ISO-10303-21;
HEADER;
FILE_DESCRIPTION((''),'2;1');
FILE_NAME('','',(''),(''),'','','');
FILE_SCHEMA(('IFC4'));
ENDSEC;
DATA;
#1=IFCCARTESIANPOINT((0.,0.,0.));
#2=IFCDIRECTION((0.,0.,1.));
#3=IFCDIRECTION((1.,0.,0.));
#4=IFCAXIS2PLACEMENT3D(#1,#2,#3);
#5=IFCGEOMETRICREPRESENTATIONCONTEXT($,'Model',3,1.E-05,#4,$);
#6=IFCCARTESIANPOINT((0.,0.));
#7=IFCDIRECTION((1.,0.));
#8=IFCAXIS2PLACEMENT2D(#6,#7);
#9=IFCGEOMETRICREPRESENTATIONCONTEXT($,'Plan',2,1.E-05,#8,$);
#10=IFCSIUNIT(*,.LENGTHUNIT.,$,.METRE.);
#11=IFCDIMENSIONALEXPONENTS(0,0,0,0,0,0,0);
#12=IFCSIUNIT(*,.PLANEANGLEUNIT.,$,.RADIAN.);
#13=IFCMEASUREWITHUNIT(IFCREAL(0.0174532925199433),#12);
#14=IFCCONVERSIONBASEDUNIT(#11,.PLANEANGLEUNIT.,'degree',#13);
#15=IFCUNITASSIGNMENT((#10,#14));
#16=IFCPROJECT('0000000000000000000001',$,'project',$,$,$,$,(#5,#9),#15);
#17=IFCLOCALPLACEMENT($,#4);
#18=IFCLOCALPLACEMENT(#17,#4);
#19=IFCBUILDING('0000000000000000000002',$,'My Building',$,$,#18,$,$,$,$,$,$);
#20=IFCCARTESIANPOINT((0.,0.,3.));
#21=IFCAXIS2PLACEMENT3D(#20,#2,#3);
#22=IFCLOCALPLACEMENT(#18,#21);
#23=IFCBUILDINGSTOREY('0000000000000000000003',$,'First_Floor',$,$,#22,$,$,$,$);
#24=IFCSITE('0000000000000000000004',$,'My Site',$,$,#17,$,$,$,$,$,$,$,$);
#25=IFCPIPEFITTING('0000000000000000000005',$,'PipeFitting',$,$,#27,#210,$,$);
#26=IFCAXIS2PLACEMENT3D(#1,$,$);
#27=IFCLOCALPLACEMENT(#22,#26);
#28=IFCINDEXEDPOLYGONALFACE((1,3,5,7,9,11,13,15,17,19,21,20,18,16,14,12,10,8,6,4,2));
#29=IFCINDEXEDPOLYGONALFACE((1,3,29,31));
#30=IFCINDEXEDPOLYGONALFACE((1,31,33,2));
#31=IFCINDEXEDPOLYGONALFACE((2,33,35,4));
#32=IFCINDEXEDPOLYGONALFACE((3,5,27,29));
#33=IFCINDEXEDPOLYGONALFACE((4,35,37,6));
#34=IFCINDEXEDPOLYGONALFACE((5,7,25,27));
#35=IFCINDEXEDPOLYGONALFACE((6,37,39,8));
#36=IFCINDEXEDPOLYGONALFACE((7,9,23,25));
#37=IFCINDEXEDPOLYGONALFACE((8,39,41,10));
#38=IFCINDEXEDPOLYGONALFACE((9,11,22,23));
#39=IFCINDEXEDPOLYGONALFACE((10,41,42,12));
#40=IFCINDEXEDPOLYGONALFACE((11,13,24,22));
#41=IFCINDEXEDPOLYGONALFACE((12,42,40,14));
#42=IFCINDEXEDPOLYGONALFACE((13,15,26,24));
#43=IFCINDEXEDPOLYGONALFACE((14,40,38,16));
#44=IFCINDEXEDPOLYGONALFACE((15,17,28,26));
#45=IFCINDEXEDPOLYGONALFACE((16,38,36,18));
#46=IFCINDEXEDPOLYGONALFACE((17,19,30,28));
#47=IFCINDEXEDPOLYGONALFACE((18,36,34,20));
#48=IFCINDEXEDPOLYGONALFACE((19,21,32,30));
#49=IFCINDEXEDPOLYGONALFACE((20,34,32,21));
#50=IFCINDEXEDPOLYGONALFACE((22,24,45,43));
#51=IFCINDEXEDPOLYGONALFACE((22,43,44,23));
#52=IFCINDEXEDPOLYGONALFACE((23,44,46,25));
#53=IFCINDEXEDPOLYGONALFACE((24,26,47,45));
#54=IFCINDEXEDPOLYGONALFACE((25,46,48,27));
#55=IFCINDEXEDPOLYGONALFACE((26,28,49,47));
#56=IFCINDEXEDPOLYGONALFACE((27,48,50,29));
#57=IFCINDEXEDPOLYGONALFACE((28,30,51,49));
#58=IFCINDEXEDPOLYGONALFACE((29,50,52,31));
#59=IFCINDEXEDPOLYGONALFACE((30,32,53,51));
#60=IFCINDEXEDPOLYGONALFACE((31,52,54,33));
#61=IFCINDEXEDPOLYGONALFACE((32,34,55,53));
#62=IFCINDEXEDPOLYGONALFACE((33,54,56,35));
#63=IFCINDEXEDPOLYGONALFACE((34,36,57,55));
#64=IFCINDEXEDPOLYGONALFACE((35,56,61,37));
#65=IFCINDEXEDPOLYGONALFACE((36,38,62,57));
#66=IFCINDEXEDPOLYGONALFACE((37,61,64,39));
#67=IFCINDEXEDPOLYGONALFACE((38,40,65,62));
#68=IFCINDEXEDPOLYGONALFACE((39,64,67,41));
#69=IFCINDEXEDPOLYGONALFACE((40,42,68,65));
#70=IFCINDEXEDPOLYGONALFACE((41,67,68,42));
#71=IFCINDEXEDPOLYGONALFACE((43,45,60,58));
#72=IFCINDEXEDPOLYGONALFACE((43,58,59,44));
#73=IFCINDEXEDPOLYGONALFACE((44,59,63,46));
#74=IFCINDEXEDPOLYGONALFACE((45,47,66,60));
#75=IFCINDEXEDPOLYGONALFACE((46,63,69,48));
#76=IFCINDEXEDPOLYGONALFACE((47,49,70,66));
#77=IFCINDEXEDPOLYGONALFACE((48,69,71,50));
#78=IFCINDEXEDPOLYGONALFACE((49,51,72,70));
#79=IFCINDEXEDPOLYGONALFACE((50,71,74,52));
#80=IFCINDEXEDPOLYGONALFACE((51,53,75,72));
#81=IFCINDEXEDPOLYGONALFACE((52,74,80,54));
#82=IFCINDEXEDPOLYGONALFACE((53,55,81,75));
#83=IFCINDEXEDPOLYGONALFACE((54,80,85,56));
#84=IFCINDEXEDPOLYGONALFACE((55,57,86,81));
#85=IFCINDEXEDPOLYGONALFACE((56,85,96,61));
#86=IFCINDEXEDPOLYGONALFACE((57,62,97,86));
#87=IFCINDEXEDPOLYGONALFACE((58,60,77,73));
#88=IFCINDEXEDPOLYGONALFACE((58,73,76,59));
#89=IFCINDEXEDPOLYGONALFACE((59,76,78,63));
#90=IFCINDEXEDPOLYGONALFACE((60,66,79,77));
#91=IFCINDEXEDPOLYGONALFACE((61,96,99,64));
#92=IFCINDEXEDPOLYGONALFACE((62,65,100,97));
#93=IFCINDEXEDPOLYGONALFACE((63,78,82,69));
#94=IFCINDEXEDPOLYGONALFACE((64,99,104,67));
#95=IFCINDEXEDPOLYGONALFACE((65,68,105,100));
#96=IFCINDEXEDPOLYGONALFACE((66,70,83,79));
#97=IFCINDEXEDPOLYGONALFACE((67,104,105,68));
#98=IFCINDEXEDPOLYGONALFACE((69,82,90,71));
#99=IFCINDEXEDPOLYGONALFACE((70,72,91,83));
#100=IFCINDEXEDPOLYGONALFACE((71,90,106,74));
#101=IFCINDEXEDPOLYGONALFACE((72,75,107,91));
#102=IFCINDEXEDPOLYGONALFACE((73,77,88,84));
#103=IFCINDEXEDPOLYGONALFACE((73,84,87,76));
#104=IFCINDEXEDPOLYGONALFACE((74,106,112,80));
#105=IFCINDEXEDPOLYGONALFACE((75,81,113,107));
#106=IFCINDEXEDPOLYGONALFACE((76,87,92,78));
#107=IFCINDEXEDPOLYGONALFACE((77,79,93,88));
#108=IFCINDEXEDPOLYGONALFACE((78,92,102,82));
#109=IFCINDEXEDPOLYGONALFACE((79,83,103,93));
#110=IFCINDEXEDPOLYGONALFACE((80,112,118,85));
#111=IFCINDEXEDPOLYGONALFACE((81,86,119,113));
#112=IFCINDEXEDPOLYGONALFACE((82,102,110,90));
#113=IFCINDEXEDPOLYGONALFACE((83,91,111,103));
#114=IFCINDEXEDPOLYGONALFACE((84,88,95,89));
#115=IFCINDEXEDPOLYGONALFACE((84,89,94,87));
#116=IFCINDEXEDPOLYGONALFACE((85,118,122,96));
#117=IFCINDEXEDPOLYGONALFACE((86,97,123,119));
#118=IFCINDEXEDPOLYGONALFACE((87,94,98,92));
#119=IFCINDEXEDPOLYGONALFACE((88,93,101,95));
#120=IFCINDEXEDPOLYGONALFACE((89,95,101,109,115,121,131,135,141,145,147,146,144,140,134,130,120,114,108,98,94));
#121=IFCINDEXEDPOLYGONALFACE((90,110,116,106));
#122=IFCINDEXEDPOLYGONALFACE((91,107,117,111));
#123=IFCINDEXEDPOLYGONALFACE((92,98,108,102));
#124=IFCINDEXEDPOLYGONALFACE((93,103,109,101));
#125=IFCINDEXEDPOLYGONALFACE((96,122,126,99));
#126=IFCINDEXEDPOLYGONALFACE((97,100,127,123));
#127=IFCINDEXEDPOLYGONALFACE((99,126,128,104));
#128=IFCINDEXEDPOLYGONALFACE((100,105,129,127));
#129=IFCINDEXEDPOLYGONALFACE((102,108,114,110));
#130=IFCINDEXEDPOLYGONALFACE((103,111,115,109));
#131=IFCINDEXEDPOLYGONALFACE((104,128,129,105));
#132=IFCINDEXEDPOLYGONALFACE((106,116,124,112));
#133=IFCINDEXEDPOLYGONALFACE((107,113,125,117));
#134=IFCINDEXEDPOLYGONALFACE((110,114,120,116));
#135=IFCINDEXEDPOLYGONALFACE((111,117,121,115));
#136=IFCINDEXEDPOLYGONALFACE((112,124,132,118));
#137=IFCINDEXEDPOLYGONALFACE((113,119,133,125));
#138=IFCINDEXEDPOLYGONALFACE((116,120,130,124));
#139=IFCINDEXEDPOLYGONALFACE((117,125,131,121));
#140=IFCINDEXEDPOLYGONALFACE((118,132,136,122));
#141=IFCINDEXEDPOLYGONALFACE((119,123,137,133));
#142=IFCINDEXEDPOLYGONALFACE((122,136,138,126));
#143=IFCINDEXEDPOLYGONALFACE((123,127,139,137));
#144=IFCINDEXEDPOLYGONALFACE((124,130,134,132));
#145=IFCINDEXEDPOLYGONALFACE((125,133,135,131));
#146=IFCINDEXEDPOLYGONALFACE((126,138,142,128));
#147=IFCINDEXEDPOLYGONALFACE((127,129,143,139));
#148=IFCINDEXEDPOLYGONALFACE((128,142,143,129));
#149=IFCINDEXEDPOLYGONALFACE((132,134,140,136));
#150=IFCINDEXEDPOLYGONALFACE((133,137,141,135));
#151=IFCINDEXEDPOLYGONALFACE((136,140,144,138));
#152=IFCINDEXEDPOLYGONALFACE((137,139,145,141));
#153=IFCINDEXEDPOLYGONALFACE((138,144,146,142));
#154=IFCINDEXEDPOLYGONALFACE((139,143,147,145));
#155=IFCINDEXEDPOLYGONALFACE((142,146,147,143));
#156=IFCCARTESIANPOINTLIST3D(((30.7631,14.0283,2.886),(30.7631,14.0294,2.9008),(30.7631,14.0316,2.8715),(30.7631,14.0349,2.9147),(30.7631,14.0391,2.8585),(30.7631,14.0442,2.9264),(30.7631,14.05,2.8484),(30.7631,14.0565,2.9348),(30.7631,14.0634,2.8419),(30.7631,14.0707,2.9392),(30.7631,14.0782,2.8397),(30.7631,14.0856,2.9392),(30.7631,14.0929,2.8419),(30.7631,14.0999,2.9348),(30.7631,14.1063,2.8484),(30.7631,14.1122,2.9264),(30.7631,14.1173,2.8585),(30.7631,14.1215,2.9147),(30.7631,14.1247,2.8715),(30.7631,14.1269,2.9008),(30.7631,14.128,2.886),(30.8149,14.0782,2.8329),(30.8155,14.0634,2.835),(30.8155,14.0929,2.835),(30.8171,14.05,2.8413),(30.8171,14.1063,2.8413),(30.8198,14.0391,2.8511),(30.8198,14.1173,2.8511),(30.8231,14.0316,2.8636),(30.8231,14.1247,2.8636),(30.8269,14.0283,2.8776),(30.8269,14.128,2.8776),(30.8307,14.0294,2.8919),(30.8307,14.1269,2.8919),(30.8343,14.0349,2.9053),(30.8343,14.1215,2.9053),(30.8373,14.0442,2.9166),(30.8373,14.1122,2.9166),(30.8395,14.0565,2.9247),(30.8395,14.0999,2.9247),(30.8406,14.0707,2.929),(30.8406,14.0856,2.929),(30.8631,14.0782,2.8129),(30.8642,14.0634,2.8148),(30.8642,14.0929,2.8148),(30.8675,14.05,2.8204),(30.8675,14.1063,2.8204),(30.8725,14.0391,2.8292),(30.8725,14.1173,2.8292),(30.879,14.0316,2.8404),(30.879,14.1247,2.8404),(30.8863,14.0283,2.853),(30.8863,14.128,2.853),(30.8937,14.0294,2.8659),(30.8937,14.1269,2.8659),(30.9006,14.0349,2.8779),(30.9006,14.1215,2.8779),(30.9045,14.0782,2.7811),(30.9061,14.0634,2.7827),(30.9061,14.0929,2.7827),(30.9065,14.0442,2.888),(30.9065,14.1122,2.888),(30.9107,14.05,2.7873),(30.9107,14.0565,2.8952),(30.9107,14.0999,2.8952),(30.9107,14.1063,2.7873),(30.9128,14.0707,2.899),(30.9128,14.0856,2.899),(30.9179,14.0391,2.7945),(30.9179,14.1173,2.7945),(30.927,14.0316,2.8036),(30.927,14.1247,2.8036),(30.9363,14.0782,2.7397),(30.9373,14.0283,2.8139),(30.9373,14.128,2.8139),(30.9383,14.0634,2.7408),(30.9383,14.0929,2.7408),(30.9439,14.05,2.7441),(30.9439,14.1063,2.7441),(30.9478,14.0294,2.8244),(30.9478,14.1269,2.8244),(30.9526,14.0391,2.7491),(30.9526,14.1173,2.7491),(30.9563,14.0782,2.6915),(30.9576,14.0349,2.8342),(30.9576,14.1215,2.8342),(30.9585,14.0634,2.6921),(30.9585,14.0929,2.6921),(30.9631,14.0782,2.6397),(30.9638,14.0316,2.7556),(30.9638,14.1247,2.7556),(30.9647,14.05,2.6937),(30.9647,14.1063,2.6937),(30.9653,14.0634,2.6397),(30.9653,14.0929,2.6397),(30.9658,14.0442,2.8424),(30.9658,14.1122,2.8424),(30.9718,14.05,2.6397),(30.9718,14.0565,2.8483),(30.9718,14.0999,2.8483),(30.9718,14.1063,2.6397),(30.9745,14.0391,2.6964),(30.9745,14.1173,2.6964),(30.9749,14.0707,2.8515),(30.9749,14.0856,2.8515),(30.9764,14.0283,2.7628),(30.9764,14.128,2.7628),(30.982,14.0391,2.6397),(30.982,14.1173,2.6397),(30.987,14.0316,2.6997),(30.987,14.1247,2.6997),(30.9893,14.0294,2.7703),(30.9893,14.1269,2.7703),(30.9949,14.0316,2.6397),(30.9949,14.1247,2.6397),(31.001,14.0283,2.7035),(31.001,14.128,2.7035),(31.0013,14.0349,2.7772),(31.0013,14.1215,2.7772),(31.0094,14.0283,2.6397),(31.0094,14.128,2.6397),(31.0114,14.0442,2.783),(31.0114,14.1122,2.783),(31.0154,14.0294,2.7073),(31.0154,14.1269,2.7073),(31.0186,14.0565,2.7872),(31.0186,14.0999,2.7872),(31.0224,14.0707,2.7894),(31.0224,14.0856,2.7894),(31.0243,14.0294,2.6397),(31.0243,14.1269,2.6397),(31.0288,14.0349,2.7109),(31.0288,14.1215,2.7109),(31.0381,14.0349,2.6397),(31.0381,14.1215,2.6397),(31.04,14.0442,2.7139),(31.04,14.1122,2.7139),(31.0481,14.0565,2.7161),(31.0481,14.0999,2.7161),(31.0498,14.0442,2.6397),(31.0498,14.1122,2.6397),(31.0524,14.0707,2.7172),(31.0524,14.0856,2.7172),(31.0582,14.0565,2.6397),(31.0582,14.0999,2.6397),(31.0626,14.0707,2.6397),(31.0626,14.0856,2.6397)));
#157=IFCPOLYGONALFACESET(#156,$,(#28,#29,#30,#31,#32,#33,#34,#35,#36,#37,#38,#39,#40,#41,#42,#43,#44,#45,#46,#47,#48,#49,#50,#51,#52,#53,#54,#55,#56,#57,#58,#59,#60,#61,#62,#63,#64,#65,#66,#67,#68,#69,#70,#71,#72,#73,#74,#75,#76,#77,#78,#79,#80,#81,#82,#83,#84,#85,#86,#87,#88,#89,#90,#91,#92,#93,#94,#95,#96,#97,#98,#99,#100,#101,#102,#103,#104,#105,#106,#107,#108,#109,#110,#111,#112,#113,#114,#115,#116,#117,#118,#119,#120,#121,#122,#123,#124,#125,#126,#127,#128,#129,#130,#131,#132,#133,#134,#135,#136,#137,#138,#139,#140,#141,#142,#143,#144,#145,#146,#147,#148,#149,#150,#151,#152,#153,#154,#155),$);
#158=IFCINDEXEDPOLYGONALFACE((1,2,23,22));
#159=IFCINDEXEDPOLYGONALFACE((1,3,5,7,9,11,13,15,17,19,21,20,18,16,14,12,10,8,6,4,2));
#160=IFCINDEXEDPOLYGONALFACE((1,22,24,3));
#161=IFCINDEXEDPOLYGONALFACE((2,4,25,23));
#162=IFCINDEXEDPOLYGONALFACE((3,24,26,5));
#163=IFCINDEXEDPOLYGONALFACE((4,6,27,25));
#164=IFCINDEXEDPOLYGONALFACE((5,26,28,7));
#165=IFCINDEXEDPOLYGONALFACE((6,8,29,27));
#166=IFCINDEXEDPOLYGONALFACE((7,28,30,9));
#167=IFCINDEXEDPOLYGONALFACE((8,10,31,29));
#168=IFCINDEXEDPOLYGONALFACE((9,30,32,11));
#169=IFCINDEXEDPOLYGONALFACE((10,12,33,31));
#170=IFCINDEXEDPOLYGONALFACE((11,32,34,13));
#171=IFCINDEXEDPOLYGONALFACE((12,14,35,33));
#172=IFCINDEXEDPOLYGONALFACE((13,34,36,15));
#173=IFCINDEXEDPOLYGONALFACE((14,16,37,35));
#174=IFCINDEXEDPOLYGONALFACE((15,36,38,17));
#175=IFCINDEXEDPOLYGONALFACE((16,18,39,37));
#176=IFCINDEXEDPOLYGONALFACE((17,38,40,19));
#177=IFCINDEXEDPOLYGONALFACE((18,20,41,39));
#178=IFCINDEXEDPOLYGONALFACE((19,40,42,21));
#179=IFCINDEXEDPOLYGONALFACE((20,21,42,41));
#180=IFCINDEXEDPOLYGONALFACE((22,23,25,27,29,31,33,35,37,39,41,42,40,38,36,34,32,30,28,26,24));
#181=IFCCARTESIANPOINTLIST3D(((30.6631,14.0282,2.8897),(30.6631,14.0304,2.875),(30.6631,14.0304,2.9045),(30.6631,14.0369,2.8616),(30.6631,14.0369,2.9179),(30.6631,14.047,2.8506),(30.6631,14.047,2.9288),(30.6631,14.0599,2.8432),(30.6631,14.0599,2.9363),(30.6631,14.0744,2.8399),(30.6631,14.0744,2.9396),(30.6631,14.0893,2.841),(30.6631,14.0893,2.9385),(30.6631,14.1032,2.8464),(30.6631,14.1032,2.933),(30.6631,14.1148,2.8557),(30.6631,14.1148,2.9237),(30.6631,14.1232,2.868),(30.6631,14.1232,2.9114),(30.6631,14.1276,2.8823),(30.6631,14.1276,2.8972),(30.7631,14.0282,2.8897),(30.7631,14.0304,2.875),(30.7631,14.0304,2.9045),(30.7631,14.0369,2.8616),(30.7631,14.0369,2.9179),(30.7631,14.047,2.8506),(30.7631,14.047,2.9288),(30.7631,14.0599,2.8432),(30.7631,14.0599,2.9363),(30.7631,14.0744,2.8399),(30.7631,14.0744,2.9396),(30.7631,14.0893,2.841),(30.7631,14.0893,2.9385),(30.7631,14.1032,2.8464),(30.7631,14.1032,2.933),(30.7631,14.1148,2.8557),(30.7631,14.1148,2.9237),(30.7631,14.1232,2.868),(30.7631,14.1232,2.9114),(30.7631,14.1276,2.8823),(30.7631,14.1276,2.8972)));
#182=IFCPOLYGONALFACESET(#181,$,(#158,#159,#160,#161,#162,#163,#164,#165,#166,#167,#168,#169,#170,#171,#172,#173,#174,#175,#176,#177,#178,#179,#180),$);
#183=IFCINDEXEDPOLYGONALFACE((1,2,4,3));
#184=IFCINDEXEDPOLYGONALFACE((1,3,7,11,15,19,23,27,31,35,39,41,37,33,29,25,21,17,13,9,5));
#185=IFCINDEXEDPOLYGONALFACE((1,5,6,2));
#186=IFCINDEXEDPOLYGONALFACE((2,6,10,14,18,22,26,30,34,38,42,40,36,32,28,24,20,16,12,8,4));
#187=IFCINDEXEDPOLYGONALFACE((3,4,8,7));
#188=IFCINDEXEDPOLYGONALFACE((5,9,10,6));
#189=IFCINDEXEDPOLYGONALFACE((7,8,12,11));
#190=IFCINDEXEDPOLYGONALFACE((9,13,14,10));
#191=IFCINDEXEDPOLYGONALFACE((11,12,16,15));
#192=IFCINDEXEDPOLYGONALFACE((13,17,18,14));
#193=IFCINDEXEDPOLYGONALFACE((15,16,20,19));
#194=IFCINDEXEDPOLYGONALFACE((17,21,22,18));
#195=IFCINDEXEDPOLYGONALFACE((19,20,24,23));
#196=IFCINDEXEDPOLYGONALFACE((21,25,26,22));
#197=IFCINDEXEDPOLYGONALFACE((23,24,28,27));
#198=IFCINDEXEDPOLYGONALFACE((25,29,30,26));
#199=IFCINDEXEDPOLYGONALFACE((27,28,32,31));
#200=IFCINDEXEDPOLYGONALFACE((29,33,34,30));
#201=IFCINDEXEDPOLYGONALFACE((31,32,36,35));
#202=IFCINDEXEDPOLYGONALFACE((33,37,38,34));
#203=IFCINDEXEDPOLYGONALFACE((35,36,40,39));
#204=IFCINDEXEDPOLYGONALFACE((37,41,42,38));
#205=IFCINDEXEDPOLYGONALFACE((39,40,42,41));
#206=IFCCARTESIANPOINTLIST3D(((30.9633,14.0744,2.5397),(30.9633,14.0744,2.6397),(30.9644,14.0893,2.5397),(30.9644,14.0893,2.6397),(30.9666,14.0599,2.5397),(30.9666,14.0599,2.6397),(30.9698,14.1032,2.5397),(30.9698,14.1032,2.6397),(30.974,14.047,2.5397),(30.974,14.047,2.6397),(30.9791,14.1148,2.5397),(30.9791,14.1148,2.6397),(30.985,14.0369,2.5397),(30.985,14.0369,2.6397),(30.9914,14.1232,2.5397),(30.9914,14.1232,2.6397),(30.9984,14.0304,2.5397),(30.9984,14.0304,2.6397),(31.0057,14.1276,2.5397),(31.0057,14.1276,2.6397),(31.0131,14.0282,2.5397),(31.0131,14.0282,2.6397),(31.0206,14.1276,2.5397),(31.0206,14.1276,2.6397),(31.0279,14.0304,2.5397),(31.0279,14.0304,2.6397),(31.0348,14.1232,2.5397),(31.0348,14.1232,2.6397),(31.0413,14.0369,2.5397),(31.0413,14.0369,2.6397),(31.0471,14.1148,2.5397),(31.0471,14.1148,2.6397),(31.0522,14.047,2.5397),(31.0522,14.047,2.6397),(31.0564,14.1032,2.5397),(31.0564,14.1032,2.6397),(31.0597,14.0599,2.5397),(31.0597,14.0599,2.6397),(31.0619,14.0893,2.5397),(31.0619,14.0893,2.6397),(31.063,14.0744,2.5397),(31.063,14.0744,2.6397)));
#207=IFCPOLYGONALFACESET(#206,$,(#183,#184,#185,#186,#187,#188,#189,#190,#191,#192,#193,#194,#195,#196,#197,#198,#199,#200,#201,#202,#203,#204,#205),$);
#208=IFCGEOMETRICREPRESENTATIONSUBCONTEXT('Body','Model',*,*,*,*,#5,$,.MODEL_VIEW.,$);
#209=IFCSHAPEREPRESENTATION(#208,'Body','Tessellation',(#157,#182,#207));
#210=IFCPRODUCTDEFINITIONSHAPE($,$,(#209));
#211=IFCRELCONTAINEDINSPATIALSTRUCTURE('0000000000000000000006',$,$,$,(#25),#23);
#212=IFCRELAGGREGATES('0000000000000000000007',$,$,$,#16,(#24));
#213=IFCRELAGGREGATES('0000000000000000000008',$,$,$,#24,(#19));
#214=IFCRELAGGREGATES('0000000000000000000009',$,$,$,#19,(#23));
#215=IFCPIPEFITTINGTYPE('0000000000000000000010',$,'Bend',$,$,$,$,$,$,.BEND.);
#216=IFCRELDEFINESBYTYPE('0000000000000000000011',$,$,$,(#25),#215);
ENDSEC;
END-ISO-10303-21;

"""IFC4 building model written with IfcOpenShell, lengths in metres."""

from ifc_helpers import new_model, entity, si_unit, converted_unit, frame, origin_with_axes, origin_2d_with_axis, place, context, subcontext, project, spatial, circle, extrude, source, transform, mapped, type_object, type_shapes, element, save


model = new_model("IFC4")

# Units and contexts
model_context = context("Model", 3, precision=1e-05, world=origin_with_axes())
plan_context = context("Plan", 2, precision=1e-05, world=origin_2d_with_axis())
body_context_1 = subcontext(model_context, "Body", "Model", "MODEL_VIEW")
ifc_project = project(units=[si_unit("LENGTHUNIT", "METRE"), converted_unit("PLANEANGLEUNIT", "degree", entity("IfcReal", 0.0174532925199433), si_unit("PLANEANGLEUNIT", "RADIAN"), dimensions=[0, 0, 0, 0, 0, 0, 0])], contexts=[model_context, plan_context])

# Site, building, storey
site_placement = place(None, origin_with_axes())
site = spatial("IfcSite", under=ifc_project, at=site_placement, Name="My Site")
building_placement = place(site_placement, origin_with_axes())
building = spatial("IfcBuilding", under=site, at=building_placement, Name="My Building")
storey_placement = place(building_placement, frame((0.0, 0.0, 3.0), z_axis=(0.0, 0.0, 1.0), x_axis=(1.0, 0.0, 0.0)))
storey = spatial("IfcBuildingStorey", under=building, at=storey_placement, Name="First_Floor")

# Pipe fitting
pipe_fitting_type = type_object("IfcPipeFittingType", Name="Bend", PredefinedType="BEND")
shared_shape_1 = source(origin_with_axes(), body_context_1, "Body", "SolidModel", [
    entity("IfcSweptDiskSolid", entity("IfcIndexedPolyCurve", entity("IfcCartesianPointList3D", [[0.0, 0.0, -0.1], [0.0, -0.0732, -0.2768], [0.0, -0.25, -0.35]]), [entity("IfcArcIndex", [1, 2, 3])]), 0.05),
    extrude(circle(Radius=0.05), origin_with_axes(), (0.0, 0.0, -1.0), 0.1),
    extrude(circle(Radius=0.05), frame((0.0, -0.25, -0.35), z_axis=(0.0, -1.0, 0.0), x_axis=(1.0, 0.0, 0.0)), (0.0, 0.0, 1.0), 0.1),
])
type_shapes(pipe_fitting_type, [shared_shape_1])
for number, where, z_axis, x_axis, name in (
    (1, (30.6631, 14.0782, 2.8897), (-1.0, 0.0, 0.0), (0.0, -1.0, 0.0), "PipeFitting"),
):
    element("IfcPipeFitting", number, at=place(storey_placement, frame(where, z_axis=z_axis, x_axis=x_axis)), inside=storey, type_object=pipe_fitting_type, Name=name, context=body_context_1, shape_type="MappedRepresentation", body=[
        mapped(shared_shape_1, transform((0.0, 0.0, 0.0), x_axis=(1.0, 0.0, 0.0), y_axis=(0.0, 1.0, 0.0), z_axis=(0.0, 0.0, 1.0), scale=1.0)),
    ])

save(model, "model.ifc")
